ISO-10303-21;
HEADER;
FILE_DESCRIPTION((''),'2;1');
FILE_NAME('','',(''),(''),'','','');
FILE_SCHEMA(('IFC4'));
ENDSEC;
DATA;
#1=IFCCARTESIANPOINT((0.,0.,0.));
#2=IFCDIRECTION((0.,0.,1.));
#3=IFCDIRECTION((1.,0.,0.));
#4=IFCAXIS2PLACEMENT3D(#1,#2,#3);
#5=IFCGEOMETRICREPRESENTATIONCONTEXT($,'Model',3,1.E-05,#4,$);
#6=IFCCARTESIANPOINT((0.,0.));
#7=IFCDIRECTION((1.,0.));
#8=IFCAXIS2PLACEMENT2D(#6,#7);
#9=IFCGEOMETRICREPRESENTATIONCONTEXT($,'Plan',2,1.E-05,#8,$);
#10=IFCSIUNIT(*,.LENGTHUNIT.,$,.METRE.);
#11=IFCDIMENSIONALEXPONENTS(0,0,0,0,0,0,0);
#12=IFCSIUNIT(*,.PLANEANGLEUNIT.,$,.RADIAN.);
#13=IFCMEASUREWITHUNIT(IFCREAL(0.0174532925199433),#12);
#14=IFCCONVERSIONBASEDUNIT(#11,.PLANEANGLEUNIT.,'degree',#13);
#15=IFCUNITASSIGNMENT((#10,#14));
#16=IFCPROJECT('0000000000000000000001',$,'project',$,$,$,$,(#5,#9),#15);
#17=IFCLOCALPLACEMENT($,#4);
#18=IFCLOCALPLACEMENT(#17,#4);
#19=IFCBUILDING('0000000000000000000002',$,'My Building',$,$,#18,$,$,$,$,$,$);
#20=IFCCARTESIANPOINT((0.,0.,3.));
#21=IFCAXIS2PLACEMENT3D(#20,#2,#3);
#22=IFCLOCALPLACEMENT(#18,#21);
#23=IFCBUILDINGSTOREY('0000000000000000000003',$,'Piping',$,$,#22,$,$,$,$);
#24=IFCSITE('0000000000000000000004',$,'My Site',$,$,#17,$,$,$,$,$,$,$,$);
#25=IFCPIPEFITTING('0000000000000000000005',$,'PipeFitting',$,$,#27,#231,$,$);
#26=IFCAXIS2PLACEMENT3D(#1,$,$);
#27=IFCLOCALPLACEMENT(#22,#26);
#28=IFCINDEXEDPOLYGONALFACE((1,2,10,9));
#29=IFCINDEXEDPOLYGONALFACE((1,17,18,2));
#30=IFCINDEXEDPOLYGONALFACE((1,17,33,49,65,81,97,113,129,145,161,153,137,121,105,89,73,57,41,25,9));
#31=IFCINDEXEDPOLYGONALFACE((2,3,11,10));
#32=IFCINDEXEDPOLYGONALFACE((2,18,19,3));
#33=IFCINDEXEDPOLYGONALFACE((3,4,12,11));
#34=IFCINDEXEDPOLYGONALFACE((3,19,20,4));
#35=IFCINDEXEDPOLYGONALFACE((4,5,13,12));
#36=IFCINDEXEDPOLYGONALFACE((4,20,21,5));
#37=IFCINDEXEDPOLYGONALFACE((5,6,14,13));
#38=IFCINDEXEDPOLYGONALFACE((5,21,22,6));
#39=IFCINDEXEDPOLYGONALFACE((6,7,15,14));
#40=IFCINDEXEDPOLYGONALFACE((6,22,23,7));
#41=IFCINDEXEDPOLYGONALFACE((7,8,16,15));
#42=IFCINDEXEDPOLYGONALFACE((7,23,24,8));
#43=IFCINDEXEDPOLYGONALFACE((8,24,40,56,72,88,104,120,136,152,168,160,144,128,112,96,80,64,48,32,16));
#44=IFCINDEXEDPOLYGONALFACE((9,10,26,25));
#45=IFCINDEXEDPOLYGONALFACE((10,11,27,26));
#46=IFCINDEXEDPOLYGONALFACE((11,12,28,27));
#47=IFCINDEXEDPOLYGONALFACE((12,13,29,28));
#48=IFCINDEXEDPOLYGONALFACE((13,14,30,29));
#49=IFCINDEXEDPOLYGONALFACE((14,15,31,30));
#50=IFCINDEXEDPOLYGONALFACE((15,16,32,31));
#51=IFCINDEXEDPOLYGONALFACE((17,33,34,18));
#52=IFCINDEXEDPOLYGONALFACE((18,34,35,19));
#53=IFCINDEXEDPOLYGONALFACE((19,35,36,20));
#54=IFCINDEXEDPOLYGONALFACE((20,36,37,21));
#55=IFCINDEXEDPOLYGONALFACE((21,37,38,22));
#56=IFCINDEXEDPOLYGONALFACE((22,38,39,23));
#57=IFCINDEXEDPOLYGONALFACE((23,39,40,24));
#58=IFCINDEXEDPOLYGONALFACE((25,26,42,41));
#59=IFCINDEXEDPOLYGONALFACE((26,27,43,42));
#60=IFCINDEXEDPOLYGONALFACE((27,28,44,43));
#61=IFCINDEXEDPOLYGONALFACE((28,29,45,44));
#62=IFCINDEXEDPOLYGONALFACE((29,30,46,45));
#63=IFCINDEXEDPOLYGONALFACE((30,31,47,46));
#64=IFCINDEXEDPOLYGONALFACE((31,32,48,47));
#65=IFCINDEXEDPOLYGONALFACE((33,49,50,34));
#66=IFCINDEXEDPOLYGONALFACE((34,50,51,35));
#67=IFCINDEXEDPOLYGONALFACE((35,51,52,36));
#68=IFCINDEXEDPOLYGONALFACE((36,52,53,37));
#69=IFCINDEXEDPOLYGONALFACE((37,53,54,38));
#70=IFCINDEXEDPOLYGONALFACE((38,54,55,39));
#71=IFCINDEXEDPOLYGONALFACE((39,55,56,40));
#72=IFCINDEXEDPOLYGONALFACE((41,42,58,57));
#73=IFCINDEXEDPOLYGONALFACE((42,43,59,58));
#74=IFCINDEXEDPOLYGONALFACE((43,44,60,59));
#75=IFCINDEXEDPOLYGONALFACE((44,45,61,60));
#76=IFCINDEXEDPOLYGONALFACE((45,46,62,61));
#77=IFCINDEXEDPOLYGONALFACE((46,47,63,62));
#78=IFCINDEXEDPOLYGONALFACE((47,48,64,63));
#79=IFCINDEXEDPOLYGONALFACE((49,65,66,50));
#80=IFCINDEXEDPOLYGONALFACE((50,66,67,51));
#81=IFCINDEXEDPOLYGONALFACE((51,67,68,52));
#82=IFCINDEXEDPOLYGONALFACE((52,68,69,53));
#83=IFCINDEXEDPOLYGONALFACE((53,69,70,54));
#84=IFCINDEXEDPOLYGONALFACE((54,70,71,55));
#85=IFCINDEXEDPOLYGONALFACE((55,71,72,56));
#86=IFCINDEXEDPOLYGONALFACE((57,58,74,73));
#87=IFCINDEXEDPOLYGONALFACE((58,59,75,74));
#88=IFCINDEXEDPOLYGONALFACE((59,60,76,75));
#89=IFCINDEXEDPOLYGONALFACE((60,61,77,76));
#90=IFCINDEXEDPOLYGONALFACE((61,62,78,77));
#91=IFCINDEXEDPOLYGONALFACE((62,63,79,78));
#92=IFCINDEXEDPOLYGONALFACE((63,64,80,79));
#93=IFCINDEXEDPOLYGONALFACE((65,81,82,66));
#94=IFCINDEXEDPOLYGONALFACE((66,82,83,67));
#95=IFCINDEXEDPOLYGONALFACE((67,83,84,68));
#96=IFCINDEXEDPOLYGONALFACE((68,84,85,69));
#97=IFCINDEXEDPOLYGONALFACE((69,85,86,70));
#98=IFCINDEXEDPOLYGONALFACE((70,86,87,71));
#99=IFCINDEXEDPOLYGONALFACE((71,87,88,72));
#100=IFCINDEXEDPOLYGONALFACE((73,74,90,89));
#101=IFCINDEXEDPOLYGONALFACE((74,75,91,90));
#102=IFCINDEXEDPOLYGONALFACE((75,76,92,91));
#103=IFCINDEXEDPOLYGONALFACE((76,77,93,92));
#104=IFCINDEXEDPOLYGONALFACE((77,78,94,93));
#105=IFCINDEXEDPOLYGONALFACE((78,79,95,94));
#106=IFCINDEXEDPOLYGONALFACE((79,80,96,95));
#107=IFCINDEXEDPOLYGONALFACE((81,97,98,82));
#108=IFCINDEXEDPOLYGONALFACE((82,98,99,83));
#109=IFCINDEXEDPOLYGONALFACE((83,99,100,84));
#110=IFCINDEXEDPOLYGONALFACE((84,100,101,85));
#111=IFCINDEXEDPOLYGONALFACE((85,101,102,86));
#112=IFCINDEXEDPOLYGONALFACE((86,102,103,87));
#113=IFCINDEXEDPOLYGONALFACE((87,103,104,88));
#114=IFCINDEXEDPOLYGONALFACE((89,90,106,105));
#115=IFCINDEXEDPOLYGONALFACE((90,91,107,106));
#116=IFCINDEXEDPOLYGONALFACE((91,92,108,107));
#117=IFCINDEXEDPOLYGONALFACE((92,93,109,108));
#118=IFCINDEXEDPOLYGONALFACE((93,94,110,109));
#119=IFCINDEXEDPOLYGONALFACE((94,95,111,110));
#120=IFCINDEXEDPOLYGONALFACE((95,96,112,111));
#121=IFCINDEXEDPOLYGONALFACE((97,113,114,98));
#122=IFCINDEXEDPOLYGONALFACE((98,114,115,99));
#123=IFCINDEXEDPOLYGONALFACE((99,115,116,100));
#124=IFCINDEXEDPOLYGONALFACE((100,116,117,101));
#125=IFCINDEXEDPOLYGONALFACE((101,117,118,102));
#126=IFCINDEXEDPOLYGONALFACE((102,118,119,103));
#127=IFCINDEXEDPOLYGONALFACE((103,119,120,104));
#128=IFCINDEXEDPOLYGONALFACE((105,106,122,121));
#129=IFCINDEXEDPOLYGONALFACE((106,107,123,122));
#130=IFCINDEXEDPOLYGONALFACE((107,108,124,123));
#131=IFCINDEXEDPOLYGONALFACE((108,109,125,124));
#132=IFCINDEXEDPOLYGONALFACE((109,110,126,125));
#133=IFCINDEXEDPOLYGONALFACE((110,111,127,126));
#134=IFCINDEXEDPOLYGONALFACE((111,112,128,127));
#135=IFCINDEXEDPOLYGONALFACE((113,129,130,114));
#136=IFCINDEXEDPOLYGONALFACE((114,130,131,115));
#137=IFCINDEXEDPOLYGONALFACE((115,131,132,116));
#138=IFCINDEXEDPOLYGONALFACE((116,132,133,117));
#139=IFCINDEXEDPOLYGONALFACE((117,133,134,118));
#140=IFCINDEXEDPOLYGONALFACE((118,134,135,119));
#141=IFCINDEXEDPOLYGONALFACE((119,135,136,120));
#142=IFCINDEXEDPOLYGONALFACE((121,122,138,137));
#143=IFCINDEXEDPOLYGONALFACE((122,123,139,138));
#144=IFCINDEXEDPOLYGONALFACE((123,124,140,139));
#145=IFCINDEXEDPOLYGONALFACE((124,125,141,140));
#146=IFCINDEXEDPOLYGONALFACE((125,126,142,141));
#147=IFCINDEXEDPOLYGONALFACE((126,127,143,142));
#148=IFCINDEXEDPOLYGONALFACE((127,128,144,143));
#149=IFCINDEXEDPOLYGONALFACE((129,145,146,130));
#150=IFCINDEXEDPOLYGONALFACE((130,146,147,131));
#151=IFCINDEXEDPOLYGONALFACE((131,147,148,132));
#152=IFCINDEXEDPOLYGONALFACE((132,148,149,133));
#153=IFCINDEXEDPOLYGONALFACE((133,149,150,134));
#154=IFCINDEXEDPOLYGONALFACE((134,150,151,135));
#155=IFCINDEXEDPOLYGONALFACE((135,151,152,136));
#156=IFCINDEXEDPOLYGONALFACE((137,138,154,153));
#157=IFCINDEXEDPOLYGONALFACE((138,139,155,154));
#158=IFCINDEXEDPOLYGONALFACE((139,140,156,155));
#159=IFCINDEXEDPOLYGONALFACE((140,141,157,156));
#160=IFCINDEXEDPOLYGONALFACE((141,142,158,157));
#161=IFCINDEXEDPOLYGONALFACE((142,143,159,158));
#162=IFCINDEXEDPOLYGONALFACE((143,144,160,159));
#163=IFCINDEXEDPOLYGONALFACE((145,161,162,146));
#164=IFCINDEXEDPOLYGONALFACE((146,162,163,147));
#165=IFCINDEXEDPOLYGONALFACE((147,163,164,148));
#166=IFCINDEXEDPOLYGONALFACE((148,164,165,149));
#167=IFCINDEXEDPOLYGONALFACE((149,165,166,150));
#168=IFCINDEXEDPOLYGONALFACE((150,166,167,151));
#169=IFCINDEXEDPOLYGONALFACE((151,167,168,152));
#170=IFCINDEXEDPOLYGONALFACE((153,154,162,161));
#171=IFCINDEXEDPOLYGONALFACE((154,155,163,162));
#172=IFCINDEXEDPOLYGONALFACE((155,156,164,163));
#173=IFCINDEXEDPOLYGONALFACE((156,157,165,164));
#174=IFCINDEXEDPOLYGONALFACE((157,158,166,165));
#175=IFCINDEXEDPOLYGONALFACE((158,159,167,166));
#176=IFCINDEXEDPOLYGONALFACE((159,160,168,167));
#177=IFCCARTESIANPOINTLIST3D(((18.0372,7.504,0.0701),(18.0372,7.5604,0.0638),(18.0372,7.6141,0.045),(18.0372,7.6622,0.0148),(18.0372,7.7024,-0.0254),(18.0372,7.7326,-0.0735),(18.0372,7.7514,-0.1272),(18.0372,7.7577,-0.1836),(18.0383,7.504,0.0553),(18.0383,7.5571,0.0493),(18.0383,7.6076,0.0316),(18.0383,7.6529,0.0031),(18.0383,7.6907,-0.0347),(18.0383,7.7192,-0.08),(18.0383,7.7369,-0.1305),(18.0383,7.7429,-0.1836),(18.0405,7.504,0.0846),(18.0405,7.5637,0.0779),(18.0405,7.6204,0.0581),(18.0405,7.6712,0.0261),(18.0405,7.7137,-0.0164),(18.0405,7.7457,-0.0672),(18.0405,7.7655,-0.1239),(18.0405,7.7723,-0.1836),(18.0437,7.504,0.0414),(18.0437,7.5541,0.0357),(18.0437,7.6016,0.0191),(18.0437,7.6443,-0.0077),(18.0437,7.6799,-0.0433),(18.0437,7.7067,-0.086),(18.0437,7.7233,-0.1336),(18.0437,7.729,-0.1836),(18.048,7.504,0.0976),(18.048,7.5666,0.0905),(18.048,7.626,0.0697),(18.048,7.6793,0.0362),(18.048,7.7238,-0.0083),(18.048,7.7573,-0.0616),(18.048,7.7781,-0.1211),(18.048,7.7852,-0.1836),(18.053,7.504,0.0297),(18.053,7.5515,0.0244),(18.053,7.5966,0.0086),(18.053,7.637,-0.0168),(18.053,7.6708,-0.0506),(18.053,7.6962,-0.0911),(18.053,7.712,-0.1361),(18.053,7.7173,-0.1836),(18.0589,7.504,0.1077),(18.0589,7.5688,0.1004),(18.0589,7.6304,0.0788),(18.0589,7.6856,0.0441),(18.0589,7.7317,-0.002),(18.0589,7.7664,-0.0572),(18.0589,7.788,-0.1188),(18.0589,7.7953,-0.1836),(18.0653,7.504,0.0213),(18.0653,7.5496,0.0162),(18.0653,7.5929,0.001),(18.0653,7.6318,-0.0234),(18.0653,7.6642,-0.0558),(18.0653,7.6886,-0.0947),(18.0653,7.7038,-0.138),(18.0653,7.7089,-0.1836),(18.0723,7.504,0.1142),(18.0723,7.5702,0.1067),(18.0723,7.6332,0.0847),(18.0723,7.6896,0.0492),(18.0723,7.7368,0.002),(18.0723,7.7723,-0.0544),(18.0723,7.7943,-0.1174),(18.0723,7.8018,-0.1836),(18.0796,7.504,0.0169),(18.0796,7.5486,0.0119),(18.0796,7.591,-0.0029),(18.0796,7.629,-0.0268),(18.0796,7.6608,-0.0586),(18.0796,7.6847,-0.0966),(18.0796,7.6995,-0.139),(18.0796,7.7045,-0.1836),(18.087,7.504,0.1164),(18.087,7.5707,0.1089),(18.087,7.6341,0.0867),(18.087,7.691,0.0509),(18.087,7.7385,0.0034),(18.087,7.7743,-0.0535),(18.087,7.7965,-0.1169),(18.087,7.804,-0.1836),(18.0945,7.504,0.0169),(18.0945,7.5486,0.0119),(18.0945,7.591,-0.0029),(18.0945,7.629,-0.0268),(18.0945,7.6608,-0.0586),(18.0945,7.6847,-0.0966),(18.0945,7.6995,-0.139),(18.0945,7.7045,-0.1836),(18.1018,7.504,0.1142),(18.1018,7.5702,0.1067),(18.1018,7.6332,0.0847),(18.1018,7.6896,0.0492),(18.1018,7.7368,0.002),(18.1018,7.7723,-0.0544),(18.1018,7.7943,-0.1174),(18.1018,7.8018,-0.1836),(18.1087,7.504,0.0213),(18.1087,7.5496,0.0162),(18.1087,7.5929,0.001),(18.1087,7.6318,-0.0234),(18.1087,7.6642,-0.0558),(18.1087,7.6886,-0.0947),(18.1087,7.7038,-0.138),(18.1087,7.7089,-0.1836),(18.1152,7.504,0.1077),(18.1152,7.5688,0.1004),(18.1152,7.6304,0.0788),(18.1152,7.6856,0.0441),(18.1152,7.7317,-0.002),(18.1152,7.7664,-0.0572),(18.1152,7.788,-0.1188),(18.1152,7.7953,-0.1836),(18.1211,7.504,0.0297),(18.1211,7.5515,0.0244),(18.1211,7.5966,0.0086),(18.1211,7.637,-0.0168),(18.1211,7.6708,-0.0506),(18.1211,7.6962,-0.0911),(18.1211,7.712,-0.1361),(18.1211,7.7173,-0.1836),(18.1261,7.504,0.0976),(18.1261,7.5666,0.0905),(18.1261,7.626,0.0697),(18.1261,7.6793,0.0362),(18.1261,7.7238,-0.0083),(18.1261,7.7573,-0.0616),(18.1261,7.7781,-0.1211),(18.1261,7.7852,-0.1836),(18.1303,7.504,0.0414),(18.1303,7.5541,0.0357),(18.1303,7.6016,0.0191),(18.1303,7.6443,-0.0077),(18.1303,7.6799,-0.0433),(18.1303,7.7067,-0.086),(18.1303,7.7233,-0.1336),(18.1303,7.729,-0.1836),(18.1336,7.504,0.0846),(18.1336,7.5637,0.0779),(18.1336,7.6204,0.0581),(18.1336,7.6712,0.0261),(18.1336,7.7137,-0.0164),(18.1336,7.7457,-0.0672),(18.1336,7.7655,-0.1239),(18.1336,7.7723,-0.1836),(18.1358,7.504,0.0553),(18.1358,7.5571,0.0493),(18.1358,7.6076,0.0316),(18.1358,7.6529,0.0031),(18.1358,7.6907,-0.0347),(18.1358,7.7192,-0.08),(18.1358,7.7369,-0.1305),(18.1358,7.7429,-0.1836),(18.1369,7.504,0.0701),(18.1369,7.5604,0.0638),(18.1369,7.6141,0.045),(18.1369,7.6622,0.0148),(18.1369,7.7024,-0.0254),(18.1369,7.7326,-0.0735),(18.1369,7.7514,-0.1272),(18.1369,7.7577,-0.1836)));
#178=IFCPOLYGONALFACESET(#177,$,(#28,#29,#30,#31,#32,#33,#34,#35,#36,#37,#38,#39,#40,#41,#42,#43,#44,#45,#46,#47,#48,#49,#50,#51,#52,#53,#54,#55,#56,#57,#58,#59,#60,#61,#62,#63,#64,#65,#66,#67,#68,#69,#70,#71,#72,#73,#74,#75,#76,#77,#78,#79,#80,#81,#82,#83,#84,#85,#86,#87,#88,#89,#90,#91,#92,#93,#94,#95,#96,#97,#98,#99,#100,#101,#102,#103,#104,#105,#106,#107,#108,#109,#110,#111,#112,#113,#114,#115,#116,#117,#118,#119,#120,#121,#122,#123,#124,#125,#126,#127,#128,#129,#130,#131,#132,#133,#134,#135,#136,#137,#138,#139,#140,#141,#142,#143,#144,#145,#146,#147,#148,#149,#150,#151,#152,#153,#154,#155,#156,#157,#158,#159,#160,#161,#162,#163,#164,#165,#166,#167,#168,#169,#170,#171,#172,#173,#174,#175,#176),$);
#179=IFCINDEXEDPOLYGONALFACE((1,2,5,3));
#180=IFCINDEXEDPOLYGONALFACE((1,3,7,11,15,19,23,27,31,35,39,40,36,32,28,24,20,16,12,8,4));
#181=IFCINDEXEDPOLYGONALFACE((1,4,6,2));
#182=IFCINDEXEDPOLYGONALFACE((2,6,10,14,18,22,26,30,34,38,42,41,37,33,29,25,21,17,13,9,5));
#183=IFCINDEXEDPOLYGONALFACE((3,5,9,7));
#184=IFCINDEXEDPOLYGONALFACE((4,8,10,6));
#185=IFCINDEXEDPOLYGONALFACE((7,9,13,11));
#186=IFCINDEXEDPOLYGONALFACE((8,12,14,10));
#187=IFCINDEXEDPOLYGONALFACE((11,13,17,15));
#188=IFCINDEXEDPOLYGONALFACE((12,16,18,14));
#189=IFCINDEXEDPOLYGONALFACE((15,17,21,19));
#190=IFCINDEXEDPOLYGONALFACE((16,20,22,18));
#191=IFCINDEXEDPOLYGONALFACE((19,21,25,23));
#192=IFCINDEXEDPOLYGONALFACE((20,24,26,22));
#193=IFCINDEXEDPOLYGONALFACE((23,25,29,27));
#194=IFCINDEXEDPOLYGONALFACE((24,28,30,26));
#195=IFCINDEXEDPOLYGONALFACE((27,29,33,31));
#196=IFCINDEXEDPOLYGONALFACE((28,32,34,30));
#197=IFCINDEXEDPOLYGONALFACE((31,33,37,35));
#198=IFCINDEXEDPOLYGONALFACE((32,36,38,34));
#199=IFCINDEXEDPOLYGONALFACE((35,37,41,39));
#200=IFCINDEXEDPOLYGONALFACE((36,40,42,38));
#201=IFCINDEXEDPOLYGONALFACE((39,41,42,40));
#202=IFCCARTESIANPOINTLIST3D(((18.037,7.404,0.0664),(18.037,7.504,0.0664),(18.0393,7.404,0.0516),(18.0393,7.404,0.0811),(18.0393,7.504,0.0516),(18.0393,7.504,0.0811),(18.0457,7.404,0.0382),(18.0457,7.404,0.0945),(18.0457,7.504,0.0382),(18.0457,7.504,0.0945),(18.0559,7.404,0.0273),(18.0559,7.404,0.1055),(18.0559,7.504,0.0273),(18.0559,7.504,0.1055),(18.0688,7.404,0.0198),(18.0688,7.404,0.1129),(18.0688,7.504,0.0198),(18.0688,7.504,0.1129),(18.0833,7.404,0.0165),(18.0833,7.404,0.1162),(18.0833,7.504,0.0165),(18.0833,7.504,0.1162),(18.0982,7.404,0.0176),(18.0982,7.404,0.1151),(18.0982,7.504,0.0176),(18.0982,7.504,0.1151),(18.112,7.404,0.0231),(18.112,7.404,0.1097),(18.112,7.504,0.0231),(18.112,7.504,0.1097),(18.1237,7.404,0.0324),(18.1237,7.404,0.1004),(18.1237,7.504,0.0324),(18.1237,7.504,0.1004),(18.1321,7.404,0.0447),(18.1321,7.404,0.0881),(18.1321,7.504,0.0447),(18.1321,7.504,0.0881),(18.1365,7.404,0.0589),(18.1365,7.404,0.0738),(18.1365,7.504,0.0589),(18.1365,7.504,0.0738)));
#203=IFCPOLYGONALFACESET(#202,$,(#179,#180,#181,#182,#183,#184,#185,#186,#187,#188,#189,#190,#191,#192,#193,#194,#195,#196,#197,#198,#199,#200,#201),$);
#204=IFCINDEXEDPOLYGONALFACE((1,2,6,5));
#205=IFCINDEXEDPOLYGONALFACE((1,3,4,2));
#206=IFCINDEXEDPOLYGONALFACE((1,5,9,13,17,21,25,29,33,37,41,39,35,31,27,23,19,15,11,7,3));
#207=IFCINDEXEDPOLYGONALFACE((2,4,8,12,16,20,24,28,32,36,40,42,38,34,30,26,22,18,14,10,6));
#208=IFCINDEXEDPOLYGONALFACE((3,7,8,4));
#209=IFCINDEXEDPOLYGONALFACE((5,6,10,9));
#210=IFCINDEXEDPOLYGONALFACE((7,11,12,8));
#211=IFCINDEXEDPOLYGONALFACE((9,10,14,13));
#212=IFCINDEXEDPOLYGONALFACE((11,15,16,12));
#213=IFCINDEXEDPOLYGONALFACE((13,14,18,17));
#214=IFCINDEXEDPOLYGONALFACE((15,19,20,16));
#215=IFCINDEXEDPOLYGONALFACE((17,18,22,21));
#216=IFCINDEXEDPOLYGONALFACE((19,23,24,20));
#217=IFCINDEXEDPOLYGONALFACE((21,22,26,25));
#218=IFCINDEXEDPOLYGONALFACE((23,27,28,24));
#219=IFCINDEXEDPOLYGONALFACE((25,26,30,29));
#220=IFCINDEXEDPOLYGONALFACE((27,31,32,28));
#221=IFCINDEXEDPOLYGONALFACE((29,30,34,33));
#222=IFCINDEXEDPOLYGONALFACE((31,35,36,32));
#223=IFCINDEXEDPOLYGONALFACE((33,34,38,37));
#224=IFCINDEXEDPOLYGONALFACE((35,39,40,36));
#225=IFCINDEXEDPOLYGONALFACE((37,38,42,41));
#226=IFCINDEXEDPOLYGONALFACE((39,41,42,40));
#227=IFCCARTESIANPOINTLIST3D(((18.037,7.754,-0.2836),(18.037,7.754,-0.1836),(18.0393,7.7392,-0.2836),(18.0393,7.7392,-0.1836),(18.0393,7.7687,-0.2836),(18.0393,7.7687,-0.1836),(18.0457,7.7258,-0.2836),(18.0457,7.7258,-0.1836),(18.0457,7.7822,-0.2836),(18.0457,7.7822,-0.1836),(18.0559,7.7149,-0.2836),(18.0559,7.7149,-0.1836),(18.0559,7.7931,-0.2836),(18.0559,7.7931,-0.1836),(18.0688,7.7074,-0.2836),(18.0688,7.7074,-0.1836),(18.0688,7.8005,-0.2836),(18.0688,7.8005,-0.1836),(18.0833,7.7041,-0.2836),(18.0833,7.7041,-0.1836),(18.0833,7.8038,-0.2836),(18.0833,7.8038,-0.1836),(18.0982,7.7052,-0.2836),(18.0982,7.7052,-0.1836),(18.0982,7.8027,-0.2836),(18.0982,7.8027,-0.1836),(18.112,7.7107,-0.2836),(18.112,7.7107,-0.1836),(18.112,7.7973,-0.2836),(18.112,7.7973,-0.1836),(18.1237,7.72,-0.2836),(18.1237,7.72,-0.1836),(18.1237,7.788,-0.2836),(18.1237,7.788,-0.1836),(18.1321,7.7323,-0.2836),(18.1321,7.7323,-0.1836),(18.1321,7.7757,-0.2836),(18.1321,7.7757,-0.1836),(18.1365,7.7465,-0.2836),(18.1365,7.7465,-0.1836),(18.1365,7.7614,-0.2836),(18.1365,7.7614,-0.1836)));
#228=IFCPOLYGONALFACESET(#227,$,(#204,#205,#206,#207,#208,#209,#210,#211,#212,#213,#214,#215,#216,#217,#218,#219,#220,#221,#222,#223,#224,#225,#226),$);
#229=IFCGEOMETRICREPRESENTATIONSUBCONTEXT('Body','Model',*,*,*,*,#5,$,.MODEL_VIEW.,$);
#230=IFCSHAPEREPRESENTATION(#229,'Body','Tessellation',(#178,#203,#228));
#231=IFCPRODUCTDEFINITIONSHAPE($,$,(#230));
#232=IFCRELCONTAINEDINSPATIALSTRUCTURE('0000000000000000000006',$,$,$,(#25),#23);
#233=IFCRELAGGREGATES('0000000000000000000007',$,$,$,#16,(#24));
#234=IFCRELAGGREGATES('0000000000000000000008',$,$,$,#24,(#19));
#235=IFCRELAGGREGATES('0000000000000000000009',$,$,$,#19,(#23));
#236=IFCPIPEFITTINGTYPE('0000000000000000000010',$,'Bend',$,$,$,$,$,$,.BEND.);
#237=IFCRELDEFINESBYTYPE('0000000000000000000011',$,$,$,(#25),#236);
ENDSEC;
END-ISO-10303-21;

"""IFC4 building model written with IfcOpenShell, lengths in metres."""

from ifc_helpers import new_model, entity, si_unit, converted_unit, frame, origin_with_axes, origin_2d_with_axis, place, context, subcontext, project, spatial, circle, extrude, source, transform, mapped, type_object, type_shapes, element, save


model = new_model("IFC4")

# Units and contexts
model_context = context("Model", 3, precision=1e-05, world=origin_with_axes())
plan_context = context("Plan", 2, precision=1e-05, world=origin_2d_with_axis())
body_context = subcontext(model_context, "Body", "Model", "MODEL_VIEW")
ifc_project = project(units=[si_unit("LENGTHUNIT", "METRE"), converted_unit("PLANEANGLEUNIT", "degree", entity("IfcReal", 0.0174532925199433), si_unit("PLANEANGLEUNIT", "RADIAN"), dimensions=[0, 0, 0, 0, 0, 0, 0])], contexts=[model_context, plan_context])

# Site, building, storey
site_placement = place(None, origin_with_axes())
site = spatial("IfcSite", under=ifc_project, at=site_placement, Name="My Site")
building_placement = place(site_placement, origin_with_axes())
building = spatial("IfcBuilding", under=site, at=building_placement, Name="My Building")
storey_placement = place(building_placement, frame((0.0, 0.0, 3.0), z_axis=(0.0, 0.0, 1.0), x_axis=(1.0, 0.0, 0.0)))
storey = spatial("IfcBuildingStorey", under=building, at=storey_placement, Name="Piping")

# Pipe fitting
pipe_fitting_type_1 = type_object("IfcPipeFittingType", Name="Bend", PredefinedType="BEND")
shared_shape = source(origin_with_axes(), body_context, "Body", "SolidModel", [
    entity("IfcSweptDiskSolid", entity("IfcIndexedPolyCurve", entity("IfcCartesianPointList3D", [[0.0, 0.0, 0.1], [0.0, -0.0732, 0.2768], [0.0, -0.25, 0.35]]), [entity("IfcArcIndex", [1, 2, 3])]), 0.05),
    extrude(circle(Radius=0.05), origin_with_axes(), (0.0, 0.0, 1.0), 0.1),
    extrude(circle(Radius=0.05), frame((0.0, -0.25, 0.35), z_axis=(0.0, -1.0, -0.000002), x_axis=(1.0, 0.0, 0.0)), (0.0, 0.0, 1.0), 0.1),
])
type_shapes(pipe_fitting_type_1, [shared_shape])
for number, where, z_axis, x_axis, name in (
    (1, (18.087, 7.404, 0.0664), (0.0, 1.0, 0.000002), (-1.0, 0.0, 0.0), "PipeFitting"),
):
    element("IfcPipeFitting", number, at=place(storey_placement, frame(where, z_axis=z_axis, x_axis=x_axis)), inside=storey, type_object=pipe_fitting_type_1, Name=name, context=body_context, shape_type="MappedRepresentation", body=[
        mapped(shared_shape, transform((0.0, 0.0, 0.0), x_axis=(1.0, 0.0, 0.0), y_axis=(0.0, 1.0, 0.0), z_axis=(0.0, 0.0, 1.0), scale=1.0)),
    ])

save(model, "model.ifc")
